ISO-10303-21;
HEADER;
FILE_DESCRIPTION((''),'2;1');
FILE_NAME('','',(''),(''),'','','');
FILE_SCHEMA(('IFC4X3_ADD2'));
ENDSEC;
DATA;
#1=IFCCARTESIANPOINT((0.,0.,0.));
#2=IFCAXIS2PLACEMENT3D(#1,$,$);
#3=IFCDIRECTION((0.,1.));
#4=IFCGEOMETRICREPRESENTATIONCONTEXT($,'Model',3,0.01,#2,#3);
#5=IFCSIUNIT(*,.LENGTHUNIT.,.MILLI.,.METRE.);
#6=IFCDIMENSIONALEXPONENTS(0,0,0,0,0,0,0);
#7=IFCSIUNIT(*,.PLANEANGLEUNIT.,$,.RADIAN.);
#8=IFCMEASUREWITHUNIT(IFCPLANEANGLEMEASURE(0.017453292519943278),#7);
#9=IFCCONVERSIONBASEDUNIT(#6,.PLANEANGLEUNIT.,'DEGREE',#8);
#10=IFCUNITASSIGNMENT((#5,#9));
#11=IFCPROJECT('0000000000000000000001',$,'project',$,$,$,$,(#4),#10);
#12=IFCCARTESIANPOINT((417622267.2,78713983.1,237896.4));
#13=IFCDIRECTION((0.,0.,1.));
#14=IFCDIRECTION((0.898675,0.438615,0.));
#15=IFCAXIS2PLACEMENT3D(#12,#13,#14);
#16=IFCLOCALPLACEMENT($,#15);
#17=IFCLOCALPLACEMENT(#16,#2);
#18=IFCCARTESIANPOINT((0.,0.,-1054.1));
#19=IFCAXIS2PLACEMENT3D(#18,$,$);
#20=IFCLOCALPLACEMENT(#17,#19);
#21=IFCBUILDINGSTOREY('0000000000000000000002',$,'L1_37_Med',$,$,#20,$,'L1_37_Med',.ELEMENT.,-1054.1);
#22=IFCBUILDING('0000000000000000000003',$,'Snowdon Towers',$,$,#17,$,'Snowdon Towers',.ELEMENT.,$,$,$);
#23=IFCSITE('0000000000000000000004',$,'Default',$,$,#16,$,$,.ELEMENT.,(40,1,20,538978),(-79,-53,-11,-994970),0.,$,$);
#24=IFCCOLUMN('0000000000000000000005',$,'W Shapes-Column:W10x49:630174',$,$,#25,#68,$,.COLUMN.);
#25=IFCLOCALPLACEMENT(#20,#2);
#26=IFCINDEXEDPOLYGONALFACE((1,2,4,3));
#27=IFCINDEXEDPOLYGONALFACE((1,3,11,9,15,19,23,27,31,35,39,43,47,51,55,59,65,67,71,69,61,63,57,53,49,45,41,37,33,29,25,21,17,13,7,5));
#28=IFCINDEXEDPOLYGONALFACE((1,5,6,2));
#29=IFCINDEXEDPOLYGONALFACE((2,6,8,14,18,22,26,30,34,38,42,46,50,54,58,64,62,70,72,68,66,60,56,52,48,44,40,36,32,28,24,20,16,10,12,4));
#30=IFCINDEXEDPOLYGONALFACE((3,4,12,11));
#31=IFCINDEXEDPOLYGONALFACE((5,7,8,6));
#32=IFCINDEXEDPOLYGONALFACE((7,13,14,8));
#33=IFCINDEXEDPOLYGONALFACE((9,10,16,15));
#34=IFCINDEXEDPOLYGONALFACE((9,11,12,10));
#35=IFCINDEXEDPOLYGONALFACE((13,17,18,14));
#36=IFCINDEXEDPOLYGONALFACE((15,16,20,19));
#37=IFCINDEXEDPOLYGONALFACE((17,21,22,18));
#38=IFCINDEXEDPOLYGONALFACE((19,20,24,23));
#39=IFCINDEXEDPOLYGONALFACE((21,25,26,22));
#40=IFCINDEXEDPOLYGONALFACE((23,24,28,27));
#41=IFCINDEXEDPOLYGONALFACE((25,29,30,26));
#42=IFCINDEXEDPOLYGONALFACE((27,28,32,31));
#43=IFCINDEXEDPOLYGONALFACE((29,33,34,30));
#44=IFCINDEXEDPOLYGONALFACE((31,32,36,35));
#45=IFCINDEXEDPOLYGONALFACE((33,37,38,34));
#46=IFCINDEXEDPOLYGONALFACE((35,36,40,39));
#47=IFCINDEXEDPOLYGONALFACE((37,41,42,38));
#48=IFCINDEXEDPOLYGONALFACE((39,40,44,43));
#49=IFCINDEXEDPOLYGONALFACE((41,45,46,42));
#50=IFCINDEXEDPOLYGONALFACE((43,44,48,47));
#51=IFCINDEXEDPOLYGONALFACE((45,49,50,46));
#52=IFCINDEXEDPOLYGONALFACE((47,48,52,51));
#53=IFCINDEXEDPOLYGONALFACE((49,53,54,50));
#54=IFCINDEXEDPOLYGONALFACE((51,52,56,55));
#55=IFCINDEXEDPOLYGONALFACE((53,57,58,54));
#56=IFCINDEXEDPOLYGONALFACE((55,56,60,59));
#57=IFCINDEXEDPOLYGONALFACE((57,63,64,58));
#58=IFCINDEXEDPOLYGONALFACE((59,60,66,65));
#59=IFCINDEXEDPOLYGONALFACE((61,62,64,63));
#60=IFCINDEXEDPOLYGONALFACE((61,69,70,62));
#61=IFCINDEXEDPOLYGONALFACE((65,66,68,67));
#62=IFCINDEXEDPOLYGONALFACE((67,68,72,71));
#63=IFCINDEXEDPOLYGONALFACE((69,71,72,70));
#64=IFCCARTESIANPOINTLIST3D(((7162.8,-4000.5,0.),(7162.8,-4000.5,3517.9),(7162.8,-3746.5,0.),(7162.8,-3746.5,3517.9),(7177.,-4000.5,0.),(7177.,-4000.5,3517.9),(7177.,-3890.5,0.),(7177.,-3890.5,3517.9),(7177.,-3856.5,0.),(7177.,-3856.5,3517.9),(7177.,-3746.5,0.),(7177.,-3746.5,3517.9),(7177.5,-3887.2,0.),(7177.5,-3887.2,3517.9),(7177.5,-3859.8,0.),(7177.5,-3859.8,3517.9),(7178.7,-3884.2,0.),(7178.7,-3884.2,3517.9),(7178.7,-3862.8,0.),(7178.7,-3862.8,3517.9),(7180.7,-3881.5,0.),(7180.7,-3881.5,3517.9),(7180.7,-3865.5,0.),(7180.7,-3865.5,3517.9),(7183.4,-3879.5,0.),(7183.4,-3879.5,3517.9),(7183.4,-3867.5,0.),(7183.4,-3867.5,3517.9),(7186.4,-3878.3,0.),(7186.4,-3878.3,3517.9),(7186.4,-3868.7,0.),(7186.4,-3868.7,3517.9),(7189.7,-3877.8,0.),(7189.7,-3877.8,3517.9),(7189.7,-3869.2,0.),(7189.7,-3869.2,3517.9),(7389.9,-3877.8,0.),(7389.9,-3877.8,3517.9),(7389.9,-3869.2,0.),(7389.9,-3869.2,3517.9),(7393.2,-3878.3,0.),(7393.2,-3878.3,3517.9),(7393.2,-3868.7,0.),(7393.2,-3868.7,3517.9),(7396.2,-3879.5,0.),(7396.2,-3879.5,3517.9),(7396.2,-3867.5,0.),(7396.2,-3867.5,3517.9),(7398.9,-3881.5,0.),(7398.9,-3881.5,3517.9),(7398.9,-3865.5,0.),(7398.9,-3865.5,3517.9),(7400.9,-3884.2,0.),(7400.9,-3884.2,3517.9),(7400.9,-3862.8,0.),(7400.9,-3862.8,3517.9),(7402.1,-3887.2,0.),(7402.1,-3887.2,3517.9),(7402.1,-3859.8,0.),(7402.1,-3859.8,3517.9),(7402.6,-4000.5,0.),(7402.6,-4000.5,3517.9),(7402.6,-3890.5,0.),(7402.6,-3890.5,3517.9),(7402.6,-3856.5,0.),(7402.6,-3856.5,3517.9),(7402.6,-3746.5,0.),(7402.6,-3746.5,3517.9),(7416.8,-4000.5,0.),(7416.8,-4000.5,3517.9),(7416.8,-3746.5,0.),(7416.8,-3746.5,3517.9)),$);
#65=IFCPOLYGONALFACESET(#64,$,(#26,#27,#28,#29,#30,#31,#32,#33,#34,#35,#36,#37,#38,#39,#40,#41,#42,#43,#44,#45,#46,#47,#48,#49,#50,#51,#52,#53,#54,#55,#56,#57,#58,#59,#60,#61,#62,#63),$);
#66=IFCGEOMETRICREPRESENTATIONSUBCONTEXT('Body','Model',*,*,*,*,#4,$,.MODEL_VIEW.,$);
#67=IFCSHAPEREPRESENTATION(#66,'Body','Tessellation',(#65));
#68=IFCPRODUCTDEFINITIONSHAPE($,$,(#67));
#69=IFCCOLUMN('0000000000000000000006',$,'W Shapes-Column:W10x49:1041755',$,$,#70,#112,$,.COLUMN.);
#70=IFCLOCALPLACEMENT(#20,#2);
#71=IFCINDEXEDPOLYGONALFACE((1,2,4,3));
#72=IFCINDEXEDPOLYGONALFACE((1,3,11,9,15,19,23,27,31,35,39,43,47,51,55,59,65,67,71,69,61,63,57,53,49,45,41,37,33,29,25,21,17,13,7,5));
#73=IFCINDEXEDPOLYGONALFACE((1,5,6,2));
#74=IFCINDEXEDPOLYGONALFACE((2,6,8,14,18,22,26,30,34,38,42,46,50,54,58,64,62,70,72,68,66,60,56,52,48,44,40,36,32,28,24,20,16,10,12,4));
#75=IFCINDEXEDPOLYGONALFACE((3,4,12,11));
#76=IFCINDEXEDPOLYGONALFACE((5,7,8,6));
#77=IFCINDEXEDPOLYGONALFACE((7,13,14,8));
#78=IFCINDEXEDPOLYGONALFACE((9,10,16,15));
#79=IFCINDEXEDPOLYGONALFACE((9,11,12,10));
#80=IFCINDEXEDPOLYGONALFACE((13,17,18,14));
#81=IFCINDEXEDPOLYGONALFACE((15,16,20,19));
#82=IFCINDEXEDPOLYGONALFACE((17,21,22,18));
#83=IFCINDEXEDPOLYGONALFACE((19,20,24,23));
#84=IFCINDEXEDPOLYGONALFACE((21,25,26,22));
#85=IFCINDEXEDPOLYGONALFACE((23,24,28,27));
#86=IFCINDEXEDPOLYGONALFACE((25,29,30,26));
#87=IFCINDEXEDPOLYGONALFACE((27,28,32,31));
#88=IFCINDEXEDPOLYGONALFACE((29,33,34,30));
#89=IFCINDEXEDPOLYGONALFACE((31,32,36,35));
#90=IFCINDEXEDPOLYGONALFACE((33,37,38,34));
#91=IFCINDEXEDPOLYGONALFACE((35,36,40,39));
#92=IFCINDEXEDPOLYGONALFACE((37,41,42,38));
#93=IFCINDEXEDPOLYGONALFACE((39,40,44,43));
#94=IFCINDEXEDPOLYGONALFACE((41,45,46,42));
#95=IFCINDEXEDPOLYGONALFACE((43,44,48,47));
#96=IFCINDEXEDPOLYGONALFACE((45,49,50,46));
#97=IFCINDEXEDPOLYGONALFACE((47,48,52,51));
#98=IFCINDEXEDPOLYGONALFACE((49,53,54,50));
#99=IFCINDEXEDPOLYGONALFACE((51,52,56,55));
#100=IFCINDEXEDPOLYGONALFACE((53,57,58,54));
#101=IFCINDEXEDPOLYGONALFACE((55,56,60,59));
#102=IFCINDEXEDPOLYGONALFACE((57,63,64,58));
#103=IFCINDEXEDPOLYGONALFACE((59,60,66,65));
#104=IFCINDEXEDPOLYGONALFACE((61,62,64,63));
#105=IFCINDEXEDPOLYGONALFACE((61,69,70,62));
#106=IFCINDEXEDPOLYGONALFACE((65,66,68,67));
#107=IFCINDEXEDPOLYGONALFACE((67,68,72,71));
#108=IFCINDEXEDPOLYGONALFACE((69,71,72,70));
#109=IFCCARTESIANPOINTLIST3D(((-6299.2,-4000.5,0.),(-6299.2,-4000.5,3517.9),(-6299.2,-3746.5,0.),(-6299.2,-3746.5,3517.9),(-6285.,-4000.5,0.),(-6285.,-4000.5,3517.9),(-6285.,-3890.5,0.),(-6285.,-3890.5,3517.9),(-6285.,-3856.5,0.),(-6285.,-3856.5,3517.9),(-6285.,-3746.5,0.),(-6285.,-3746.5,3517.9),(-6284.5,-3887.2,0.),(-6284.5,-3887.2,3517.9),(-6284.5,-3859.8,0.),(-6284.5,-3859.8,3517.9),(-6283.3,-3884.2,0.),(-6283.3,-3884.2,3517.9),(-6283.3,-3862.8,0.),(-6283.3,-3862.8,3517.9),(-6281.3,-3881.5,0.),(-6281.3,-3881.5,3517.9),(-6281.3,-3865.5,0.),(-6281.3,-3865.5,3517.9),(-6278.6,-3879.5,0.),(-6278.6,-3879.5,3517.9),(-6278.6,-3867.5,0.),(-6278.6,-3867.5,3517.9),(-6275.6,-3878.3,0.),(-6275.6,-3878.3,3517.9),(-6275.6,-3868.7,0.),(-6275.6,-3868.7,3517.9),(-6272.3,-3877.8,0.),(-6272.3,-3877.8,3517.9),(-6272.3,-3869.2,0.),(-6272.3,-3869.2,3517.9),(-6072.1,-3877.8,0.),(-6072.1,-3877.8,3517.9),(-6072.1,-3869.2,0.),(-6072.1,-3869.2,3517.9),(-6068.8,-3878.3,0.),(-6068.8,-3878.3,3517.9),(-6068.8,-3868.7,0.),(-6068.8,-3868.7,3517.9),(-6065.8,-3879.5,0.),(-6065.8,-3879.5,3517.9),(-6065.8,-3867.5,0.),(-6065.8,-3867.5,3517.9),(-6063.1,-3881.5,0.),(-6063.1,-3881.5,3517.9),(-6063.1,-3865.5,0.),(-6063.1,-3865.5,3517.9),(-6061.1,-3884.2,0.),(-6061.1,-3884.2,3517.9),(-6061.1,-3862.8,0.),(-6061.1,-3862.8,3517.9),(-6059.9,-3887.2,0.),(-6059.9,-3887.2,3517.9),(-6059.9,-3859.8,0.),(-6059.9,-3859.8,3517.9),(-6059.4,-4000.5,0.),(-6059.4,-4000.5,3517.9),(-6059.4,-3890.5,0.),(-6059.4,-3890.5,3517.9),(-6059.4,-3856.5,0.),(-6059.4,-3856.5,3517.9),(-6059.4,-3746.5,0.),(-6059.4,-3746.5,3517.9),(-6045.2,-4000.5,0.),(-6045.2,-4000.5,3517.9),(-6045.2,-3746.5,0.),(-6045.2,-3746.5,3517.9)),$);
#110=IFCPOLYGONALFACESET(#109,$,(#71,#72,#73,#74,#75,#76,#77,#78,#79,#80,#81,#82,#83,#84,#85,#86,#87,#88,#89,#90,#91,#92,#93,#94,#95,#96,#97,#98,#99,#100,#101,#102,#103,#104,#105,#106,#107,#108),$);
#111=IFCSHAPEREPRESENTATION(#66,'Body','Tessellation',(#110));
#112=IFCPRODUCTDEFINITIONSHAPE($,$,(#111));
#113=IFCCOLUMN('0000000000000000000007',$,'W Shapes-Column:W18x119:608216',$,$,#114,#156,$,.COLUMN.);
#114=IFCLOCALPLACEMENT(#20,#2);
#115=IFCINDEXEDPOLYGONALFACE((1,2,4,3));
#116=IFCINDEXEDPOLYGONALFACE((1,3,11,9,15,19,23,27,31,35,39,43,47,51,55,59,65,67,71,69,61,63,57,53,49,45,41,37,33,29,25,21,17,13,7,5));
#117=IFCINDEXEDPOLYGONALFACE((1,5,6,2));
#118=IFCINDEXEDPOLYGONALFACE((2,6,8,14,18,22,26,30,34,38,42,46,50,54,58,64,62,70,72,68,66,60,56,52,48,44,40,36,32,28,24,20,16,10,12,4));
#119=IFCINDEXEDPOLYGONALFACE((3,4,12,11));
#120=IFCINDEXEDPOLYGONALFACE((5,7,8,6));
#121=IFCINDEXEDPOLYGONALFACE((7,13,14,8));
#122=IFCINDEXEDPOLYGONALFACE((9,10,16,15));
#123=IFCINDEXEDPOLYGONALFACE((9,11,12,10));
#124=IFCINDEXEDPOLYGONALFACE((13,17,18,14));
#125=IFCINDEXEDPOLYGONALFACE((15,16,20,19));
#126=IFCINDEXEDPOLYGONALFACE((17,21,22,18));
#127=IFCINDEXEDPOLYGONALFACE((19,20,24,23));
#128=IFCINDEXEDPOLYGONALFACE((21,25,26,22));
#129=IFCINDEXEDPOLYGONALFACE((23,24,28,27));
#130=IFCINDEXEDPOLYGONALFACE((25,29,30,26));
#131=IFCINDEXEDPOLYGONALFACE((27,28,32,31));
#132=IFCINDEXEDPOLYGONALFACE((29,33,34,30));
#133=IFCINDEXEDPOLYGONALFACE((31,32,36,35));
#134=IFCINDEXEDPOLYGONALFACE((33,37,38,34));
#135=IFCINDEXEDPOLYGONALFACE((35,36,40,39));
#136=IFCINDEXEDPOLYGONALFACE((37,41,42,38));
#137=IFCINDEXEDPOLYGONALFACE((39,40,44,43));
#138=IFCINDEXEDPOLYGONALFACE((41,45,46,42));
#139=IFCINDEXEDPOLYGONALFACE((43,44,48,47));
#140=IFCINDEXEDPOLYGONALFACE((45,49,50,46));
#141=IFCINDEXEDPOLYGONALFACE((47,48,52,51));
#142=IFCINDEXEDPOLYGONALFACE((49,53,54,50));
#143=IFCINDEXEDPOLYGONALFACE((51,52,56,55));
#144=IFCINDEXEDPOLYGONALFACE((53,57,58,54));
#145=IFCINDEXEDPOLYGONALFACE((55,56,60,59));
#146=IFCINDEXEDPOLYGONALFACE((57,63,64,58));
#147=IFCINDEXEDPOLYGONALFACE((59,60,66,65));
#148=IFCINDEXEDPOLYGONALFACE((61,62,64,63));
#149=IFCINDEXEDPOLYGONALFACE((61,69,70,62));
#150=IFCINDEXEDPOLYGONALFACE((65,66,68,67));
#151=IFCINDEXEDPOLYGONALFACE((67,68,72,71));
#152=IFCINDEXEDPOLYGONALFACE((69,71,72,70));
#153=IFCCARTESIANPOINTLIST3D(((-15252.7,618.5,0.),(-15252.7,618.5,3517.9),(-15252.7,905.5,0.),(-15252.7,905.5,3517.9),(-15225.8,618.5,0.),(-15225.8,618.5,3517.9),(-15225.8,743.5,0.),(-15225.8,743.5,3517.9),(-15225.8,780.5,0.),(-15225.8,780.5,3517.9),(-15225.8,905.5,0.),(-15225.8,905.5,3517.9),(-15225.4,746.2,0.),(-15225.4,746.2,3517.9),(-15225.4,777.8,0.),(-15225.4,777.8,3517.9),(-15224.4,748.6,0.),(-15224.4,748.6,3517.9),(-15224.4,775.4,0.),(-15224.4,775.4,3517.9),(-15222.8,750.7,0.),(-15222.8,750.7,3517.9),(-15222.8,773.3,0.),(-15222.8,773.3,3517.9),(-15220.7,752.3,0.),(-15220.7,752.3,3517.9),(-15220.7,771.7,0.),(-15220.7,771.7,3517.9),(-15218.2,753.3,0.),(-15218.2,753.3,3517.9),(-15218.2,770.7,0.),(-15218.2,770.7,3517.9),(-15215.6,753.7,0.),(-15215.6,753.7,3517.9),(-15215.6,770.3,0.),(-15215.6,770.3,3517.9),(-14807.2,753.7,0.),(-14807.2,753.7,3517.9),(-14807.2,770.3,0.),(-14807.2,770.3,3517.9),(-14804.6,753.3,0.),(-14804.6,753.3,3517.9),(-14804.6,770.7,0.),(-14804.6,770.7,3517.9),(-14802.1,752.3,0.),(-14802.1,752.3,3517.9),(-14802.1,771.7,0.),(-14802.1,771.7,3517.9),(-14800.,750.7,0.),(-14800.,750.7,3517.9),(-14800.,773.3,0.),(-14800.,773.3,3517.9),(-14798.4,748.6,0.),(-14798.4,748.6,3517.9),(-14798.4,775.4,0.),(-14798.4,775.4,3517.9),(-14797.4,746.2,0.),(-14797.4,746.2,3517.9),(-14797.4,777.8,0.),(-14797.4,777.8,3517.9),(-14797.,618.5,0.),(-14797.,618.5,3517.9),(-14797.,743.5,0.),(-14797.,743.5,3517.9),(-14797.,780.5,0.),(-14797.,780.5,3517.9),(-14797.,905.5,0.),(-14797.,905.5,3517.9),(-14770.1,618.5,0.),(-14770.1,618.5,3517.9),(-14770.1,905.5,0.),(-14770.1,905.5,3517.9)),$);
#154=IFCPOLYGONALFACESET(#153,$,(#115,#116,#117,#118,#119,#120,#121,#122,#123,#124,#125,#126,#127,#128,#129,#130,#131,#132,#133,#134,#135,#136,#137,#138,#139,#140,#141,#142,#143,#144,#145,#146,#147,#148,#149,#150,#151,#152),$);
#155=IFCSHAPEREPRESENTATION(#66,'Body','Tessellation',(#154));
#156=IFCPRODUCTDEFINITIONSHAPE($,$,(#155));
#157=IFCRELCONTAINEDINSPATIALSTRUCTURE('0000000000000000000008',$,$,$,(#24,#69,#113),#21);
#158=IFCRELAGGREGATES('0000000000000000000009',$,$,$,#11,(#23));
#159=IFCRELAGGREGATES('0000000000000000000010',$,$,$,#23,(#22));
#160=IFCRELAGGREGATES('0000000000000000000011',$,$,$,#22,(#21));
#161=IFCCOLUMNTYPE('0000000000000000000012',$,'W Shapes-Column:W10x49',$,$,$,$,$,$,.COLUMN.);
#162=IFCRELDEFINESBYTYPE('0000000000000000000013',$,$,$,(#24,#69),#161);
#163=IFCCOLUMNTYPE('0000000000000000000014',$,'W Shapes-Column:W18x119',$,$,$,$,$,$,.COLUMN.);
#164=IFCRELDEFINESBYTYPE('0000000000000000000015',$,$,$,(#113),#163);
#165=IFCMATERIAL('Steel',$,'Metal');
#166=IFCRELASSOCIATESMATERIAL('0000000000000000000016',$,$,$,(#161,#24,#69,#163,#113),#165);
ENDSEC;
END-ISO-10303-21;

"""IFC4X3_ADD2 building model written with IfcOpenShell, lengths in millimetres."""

from ifc_helpers import new_model, entity, si_unit, converted_unit, direction, frame, frame_2d, origin, place, context, subcontext, project, spatial, i_section, extrude, source, transform, mapped, material, material_profile, profile_set, profile_usage, type_object, type_shapes, element, save


model = new_model("IFC4X3_ADD2")

# Units and contexts
model_context = context("Model", 3, precision=0.01, world=origin(), true_north=direction((0.0, 1.0)))
body_context = subcontext(model_context, "Body", "Model", "MODEL_VIEW")
ifc_project = project(units=[si_unit("LENGTHUNIT", "METRE", prefix="MILLI"), converted_unit("PLANEANGLEUNIT", "DEGREE", entity("IfcPlaneAngleMeasure", 0.017453292519943278), si_unit("PLANEANGLEUNIT", "RADIAN"), dimensions=[0, 0, 0, 0, 0, 0, 0])], contexts=[model_context])

# Site, building, storey
site_placement = place(None, frame((417622267.2, 78713983.1, 237896.4), z_axis=(0.0, 0.0, 1.0), x_axis=(0.898675, 0.438615, 0.0)))
site = spatial("IfcSite", under=ifc_project, at=site_placement, Name="Default", CompositionType="ELEMENT", RefLatitude=(40, 1, 20, 538978), RefLongitude=(-79, -53, -11, -994970), RefElevation=0.0)
building_placement = place(site_placement, origin())
building = spatial("IfcBuilding", under=site, at=building_placement, Name="Snowdon Towers", LongName="Snowdon Towers", CompositionType="ELEMENT")
storey_placement = place(building_placement, frame((0.0, 0.0, -1054.1)))
storey = spatial("IfcBuildingStorey", under=building, at=storey_placement, Name="L1_37_Med", LongName="L1_37_Med", CompositionType="ELEMENT", Elevation=-1054.1)

# Columns
ifc_material_1 = material(Name="Steel", Category="Metal")
ifc_material_profile_1 = material_profile(ifc_material_1, i_section(OverallWidth=254.0, OverallDepth=254.0, WebThickness=8.6, FlangeThickness=14.2, FilletRadius=12.7, at=frame_2d((0.0, 0.0), x_axis=(1.0, 0.0))), Name="W10x49")
ifc_profile_set_1 = profile_set([ifc_material_profile_1], Name="W10x49")
ifc_profile_usage_1 = profile_usage(ifc_profile_set_1)
column_type_1 = type_object("IfcColumnType", Name="W Shapes-Column:W10x49", PredefinedType="COLUMN", material=ifc_profile_set_1)
shared_shape_1 = source(origin(), body_context, "Body", "SweptSolid", [
    extrude(i_section(OverallWidth=254.0, OverallDepth=254.0, WebThickness=8.6, FlangeThickness=14.2, FilletRadius=12.7, at=frame_2d((0.0, 0.0), x_axis=(1.0, 0.0))), frame((0.0, 0.0, -1054.1), z_axis=(0.0, 0.0, 1.0), x_axis=(-1.0, 0.0, 0.0)), (0.0, 0.0, 1.0), 3517.9),
])
type_shapes(column_type_1, [shared_shape_1])
for number, where, z_axis, x_axis, name in (
    (1, (7289.8, -3873.5, 1054.1), (0.0, 0.0, 1.0), (0.0, 1.0, 0.0), "W Shapes-Column:W10x49:630174"),
    (2, (-6172.2, -3873.5, 1054.1), (0.0, 0.0, 1.0), (0.0, 1.0, 0.0), "W Shapes-Column:W10x49:1041755"),
):
    element("IfcColumn", number, at=place(storey_placement, frame(where, z_axis=z_axis, x_axis=x_axis)), inside=storey, type_object=column_type_1, material=ifc_profile_usage_1, Name=name, PredefinedType="COLUMN", context=body_context, shape_type="MappedRepresentation", body=[
        mapped(shared_shape_1, transform((0.0, 0.0, 0.0), scale=1.0)),
    ])
ifc_material_profile_2 = material_profile(ifc_material_1, i_section(OverallWidth=287.0, OverallDepth=482.6, WebThickness=16.6, FlangeThickness=26.9, FilletRadius=10.2, at=frame_2d((0.0, 0.0), x_axis=(1.0, 0.0))), Name="W18x119")
ifc_profile_set_2 = profile_set([ifc_material_profile_2], Name="W18x119")
ifc_profile_usage_2 = profile_usage(ifc_profile_set_2)
column_type_2 = type_object("IfcColumnType", Name="W Shapes-Column:W18x119", PredefinedType="COLUMN", material=ifc_profile_set_2)
shared_shape_2 = source(origin(), body_context, "Body", "SweptSolid", [
    extrude(i_section(OverallWidth=287.0, OverallDepth=482.6, WebThickness=16.6, FlangeThickness=26.9, FilletRadius=10.2, at=frame_2d((0.0, 0.0), x_axis=(1.0, 0.0))), frame((0.0, 0.0, -1054.1), z_axis=(0.0, 0.0, 1.0), x_axis=(-1.0, 0.0, 0.0)), (0.0, 0.0, 1.0), 3517.9),
])
type_shapes(column_type_2, [shared_shape_2])
column_1_placement = place(storey_placement, frame((-15011.4, 762.0, 1054.1), z_axis=(0.0, 0.0, 1.0), x_axis=(0.0, -1.0, 0.0)))
element("IfcColumn", 3, at=column_1_placement, inside=storey, type_object=column_type_2, material=ifc_profile_usage_2, Name="W Shapes-Column:W18x119:608216", PredefinedType="COLUMN", context=body_context, shape_type="MappedRepresentation", body=[
    mapped(shared_shape_2, transform((0.0, 0.0, 0.0), scale=1.0)),
])

save(model, "model.ifc")
